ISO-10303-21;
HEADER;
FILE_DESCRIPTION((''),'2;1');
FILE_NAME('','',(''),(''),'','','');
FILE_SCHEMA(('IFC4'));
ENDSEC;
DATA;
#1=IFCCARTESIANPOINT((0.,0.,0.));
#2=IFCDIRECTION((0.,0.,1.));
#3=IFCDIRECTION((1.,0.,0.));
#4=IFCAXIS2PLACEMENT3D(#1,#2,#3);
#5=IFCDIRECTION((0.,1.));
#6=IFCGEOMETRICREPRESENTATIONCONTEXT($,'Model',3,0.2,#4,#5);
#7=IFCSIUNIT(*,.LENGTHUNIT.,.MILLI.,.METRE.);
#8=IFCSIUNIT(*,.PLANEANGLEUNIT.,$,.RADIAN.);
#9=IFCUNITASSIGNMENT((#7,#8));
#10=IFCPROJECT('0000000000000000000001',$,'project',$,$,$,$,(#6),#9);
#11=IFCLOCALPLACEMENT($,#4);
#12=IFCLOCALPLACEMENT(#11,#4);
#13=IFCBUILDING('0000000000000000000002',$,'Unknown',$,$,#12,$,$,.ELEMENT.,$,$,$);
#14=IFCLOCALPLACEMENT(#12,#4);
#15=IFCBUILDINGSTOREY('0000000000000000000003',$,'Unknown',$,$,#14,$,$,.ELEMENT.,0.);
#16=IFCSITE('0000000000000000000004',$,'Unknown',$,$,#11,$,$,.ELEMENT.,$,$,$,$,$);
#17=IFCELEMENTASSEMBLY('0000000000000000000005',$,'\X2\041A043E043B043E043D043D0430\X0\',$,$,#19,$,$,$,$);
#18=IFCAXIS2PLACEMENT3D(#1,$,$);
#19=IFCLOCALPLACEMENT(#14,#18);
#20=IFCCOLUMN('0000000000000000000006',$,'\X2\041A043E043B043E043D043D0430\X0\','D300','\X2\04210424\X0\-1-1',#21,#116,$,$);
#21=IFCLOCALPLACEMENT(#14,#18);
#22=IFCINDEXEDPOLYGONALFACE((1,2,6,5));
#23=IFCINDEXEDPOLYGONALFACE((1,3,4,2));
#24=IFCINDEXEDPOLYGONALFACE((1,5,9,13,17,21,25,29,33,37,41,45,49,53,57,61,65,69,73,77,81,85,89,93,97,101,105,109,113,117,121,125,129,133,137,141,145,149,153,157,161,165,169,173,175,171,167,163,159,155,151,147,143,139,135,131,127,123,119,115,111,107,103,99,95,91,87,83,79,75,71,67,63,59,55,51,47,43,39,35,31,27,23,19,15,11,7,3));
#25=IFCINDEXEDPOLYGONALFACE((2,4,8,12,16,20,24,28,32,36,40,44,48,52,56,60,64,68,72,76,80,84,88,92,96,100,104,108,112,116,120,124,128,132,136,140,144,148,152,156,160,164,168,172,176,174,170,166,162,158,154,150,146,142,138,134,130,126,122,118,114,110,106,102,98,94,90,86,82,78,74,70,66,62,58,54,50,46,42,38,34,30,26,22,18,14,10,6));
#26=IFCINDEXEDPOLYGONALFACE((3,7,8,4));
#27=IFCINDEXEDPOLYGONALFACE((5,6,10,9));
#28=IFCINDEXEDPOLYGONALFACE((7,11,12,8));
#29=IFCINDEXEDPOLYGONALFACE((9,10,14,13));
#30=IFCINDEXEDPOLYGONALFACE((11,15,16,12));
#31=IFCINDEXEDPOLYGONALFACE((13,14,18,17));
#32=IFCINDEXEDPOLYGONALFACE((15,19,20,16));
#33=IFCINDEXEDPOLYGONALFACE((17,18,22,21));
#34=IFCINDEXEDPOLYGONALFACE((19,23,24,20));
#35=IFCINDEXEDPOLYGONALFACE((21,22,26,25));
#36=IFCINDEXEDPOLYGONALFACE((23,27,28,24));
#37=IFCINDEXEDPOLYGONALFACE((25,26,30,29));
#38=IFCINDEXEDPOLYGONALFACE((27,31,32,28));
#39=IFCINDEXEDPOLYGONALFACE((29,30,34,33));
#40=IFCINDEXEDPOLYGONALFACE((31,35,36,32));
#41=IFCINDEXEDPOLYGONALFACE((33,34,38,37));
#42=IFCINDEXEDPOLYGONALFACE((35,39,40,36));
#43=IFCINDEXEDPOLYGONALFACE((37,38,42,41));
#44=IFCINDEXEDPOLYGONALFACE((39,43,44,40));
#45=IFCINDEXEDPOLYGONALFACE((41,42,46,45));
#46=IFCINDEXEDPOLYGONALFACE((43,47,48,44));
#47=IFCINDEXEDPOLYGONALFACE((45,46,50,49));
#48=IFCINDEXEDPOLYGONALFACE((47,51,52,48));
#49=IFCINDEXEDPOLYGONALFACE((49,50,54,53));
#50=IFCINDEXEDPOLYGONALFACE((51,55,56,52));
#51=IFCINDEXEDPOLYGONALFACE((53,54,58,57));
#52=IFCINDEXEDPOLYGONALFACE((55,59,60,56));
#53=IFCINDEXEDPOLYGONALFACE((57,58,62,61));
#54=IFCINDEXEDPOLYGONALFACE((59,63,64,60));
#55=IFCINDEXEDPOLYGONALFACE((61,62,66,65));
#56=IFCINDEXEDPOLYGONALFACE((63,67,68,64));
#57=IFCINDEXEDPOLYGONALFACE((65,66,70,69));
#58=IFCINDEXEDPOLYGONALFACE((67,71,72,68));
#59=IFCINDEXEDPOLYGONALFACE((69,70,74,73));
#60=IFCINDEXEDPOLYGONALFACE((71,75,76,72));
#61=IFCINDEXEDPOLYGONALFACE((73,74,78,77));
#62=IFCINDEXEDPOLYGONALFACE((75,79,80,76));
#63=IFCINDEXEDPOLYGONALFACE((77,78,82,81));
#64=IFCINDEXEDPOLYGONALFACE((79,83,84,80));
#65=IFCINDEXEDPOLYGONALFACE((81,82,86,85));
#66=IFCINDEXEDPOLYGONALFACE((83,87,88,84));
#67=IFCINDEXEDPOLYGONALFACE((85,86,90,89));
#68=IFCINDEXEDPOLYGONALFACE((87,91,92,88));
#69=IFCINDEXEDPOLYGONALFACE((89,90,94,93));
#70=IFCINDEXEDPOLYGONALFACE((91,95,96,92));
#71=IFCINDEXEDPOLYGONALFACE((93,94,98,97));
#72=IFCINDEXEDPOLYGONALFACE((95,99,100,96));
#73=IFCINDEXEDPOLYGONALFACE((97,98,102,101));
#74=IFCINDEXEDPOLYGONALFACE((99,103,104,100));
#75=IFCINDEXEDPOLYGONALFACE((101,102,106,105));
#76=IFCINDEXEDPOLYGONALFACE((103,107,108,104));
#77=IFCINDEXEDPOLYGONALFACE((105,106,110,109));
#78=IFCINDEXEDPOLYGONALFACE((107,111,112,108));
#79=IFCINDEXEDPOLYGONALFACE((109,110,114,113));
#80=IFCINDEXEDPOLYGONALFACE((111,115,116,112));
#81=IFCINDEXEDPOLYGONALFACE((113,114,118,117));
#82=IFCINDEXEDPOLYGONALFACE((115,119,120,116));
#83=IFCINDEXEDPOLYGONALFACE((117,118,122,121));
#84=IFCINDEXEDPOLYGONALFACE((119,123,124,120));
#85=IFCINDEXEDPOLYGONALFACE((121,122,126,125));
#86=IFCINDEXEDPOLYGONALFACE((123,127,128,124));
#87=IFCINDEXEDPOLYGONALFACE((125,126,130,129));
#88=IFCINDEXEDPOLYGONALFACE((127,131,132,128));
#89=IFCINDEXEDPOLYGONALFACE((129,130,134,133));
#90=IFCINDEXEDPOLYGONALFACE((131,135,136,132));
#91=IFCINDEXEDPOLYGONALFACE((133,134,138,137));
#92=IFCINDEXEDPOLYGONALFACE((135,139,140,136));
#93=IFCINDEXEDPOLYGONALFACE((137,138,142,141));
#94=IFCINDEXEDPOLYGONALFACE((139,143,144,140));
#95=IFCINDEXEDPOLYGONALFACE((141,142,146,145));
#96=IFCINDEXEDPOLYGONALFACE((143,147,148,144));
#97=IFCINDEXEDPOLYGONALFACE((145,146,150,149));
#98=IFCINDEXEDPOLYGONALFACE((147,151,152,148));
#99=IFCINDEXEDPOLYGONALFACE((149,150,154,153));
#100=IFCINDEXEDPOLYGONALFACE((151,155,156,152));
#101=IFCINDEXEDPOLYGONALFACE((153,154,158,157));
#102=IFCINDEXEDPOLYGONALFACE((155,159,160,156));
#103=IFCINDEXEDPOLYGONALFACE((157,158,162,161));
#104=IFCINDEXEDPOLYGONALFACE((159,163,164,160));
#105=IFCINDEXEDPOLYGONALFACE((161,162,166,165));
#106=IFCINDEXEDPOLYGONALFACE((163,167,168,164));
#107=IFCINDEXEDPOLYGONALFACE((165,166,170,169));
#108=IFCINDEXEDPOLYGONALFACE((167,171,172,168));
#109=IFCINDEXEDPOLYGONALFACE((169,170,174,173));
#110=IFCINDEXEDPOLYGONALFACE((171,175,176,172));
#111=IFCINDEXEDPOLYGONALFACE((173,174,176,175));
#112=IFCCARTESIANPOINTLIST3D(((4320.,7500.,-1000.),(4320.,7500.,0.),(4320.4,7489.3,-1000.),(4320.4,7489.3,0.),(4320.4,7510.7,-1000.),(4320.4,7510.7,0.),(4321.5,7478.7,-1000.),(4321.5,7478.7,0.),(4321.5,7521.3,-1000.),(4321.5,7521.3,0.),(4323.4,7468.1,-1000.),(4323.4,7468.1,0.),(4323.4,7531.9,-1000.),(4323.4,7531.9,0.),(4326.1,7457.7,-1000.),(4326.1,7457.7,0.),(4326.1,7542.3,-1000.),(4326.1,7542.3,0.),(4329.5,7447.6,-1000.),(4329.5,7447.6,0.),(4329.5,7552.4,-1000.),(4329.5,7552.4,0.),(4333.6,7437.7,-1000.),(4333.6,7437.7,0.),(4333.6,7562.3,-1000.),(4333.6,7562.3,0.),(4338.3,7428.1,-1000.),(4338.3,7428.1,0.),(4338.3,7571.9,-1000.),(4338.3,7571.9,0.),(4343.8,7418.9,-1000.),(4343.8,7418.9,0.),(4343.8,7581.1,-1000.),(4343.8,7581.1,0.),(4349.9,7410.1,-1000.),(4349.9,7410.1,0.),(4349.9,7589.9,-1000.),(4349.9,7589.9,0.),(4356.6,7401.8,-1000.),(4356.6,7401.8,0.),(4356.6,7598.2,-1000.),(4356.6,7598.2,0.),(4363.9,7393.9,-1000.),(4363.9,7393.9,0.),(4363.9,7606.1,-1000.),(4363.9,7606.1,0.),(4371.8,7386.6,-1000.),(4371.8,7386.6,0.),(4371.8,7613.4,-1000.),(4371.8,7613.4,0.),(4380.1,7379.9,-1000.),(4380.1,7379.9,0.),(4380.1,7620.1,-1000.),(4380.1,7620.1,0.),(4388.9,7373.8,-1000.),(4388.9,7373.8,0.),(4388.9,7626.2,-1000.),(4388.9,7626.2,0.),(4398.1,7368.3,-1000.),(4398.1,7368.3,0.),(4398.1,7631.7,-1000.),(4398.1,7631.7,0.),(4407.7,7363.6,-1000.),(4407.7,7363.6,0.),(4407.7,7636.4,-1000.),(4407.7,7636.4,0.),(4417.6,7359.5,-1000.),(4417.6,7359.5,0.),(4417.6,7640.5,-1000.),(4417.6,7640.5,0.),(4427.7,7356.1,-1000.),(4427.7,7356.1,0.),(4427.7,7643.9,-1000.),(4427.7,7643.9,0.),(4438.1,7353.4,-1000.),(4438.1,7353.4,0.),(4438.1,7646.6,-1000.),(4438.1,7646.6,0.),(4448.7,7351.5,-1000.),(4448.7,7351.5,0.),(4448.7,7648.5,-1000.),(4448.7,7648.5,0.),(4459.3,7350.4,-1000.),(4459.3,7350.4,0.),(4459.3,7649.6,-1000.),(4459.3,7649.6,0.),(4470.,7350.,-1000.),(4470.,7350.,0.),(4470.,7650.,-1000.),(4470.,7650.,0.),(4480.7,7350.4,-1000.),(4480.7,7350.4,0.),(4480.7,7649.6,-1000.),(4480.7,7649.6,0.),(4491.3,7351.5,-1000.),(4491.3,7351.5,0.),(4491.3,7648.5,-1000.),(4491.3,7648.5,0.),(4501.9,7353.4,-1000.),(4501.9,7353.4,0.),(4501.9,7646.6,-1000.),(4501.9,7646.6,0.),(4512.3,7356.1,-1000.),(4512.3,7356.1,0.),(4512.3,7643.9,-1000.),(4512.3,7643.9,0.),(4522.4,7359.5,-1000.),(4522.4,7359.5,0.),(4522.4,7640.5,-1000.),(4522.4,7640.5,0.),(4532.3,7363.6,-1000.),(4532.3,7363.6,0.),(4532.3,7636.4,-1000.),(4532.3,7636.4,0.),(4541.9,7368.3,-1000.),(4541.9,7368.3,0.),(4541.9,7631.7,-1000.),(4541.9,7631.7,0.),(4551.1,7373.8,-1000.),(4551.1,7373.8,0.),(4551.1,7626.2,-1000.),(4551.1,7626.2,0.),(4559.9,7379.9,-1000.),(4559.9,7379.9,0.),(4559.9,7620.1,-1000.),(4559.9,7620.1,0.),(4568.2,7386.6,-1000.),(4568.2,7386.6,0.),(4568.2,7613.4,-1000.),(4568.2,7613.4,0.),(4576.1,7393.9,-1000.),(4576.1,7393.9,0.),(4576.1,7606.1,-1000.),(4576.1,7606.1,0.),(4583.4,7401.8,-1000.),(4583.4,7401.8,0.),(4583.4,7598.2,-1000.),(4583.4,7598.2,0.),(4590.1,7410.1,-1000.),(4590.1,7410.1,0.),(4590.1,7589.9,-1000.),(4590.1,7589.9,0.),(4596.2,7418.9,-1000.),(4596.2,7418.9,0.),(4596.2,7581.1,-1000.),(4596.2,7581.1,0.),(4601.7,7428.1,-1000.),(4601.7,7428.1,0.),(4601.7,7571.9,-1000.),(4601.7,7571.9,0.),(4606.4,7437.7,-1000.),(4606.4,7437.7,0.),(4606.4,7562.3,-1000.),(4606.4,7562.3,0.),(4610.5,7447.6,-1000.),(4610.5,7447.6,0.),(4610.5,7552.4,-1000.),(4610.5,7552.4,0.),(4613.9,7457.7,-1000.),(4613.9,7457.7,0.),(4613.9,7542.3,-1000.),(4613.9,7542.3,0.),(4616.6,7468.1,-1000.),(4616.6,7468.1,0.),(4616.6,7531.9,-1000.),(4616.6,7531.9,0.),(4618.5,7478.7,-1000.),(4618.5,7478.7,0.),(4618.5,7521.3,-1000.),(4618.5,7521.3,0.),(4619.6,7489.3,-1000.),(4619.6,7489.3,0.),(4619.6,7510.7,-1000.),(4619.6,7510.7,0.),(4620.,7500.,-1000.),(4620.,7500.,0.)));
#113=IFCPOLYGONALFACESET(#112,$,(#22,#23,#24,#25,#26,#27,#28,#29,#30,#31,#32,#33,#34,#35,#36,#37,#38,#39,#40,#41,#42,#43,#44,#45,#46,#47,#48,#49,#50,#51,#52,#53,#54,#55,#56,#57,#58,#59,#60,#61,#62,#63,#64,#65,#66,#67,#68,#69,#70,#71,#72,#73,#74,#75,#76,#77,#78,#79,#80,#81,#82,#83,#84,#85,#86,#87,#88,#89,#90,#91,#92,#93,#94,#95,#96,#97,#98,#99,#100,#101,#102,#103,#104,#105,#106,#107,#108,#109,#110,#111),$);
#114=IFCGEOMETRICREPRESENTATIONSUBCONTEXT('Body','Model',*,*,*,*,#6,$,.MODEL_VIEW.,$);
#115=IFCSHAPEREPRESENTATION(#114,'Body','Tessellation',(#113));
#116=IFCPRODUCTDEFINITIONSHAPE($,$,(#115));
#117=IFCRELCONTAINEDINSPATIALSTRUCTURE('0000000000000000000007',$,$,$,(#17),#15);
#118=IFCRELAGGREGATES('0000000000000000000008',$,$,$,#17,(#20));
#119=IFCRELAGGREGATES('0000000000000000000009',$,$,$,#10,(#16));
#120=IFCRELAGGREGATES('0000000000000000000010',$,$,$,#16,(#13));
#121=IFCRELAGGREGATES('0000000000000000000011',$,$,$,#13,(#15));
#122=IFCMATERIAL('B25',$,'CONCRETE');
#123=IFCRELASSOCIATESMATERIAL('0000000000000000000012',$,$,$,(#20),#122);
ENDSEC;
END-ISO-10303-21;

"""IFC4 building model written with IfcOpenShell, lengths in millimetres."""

from ifc_helpers import new_model, si_unit, direction, frame, origin_with_axes, place, context, subcontext, project, spatial, line, indexed_curve, outline, extrude, material, element, aggregate, save


model = new_model("IFC4")

# Units and contexts
model_context = context("Model", 3, precision=0.2, world=origin_with_axes(), true_north=direction((0.0, 1.0)))
body_context = subcontext(model_context, "Body", "Model", "MODEL_VIEW")
ifc_project = project(units=[si_unit("LENGTHUNIT", "METRE", prefix="MILLI"), si_unit("PLANEANGLEUNIT", "RADIAN")], contexts=[model_context])

# Site, building, storey
site_placement = place(None, origin_with_axes())
site = spatial("IfcSite", under=ifc_project, at=site_placement, Name="Unknown", CompositionType="ELEMENT")
building_placement = place(site_placement, origin_with_axes())
building = spatial("IfcBuilding", under=site, at=building_placement, Name="Unknown", CompositionType="ELEMENT")
storey_placement = place(building_placement, origin_with_axes())
storey = spatial("IfcBuildingStorey", under=building, at=storey_placement, Name="Unknown", CompositionType="ELEMENT", Elevation=0.0)

# Element assembly, column
ifc_material_1 = material(Name="B25", Category="CONCRETE")
placement_1 = place(storey_placement, frame((4470.0, 7500.0, -1000.0), z_axis=(-1.0, 0.0, 0.0), x_axis=(0.0, 0.0, 1.0)))
assembly_1 = element("IfcElementAssembly", 1, at=placement_1, inside=storey, Name="Колонна")
placement_2 = place(placement_1, origin_with_axes())
column_1 = element("IfcColumn", 2, at=placement_2, material=ifc_material_1, Name="Колонна", Description="D300", ObjectType="СФ-1-1", context=body_context, shape_type="SolidModel", body=[
    extrude(outline(indexed_curve([(150.0, 0.0), (149.6, 10.7), (148.5, 21.3), (146.6, 31.9), (143.9, 42.3), (140.5, 52.4), (136.4, 62.3), (131.7, 71.9), (126.2, 81.1), (120.1, 89.9), (113.4, 98.2), (106.1, 106.1), (98.2, 113.4), (89.9, 120.1), (81.1, 126.2), (71.9, 131.7), (62.3, 136.4), (52.4, 140.5), (42.3, 143.9), (31.9, 146.6), (21.3, 148.5), (10.7, 149.6), (0.0, 150.0), (-10.7, 149.6), (-21.3, 148.5), (-31.9, 146.6), (-42.3, 143.9), (-52.4, 140.5), (-62.3, 136.4), (-71.9, 131.7), (-81.1, 126.2), (-89.9, 120.1), (-98.2, 113.4), (-106.1, 106.1), (-113.4, 98.2), (-120.1, 89.9), (-126.2, 81.1), (-131.7, 71.9), (-136.4, 62.3), (-140.5, 52.4), (-143.9, 42.3), (-146.6, 31.9), (-148.5, 21.3), (-149.6, 10.7), (-150.0, 0.0), (-149.6, -10.7), (-148.5, -21.3), (-146.6, -31.9), (-143.9, -42.3), (-140.5, -52.4), (-136.4, -62.3), (-131.7, -71.9), (-126.2, -81.1), (-120.1, -89.9), (-113.4, -98.2), (-106.1, -106.1), (-98.2, -113.4), (-89.9, -120.1), (-81.1, -126.2), (-71.9, -131.7), (-62.3, -136.4), (-52.4, -140.5), (-42.3, -143.9), (-31.9, -146.6), (-21.3, -148.5), (-10.7, -149.6), (0.0, -150.0), (10.7, -149.6), (21.3, -148.5), (31.9, -146.6), (42.3, -143.9), (52.4, -140.5), (62.3, -136.4), (71.9, -131.7), (81.1, -126.2), (89.9, -120.1), (98.2, -113.4), (106.1, -106.1), (113.4, -98.2), (120.1, -89.9), (126.2, -81.1), (131.7, -71.9), (136.4, -62.3), (140.5, -52.4), (143.9, -42.3), (146.6, -31.9), (148.5, -21.3), (149.6, -10.7)], segments=[line(1, 2, 3, 4, 5, 6, 7, 8, 9, 10, 11, 12, 13, 14, 15, 16, 17, 18, 19, 20, 21, 22, 23, 24, 25, 26, 27, 28, 29, 30, 31, 32, 33, 34, 35, 36, 37, 38, 39, 40, 41, 42, 43, 44, 45, 46, 47, 48, 49, 50, 51, 52, 53, 54, 55, 56, 57, 58, 59, 60, 61, 62, 63, 64, 65, 66, 67, 68, 69, 70, 71, 72, 73, 74, 75, 76, 77, 78, 79, 80, 81, 82, 83, 84, 85, 86, 87, 88, 1)])), frame((0.0, 0.0, 0.0), z_axis=(-1.0, 0.0, 0.0), x_axis=(0.0, 0.0, 1.0)), (0.0, 0.0, -1.0), 1000.0),
])
aggregate(assembly_1, [column_1])

save(model, "model.ifc")
